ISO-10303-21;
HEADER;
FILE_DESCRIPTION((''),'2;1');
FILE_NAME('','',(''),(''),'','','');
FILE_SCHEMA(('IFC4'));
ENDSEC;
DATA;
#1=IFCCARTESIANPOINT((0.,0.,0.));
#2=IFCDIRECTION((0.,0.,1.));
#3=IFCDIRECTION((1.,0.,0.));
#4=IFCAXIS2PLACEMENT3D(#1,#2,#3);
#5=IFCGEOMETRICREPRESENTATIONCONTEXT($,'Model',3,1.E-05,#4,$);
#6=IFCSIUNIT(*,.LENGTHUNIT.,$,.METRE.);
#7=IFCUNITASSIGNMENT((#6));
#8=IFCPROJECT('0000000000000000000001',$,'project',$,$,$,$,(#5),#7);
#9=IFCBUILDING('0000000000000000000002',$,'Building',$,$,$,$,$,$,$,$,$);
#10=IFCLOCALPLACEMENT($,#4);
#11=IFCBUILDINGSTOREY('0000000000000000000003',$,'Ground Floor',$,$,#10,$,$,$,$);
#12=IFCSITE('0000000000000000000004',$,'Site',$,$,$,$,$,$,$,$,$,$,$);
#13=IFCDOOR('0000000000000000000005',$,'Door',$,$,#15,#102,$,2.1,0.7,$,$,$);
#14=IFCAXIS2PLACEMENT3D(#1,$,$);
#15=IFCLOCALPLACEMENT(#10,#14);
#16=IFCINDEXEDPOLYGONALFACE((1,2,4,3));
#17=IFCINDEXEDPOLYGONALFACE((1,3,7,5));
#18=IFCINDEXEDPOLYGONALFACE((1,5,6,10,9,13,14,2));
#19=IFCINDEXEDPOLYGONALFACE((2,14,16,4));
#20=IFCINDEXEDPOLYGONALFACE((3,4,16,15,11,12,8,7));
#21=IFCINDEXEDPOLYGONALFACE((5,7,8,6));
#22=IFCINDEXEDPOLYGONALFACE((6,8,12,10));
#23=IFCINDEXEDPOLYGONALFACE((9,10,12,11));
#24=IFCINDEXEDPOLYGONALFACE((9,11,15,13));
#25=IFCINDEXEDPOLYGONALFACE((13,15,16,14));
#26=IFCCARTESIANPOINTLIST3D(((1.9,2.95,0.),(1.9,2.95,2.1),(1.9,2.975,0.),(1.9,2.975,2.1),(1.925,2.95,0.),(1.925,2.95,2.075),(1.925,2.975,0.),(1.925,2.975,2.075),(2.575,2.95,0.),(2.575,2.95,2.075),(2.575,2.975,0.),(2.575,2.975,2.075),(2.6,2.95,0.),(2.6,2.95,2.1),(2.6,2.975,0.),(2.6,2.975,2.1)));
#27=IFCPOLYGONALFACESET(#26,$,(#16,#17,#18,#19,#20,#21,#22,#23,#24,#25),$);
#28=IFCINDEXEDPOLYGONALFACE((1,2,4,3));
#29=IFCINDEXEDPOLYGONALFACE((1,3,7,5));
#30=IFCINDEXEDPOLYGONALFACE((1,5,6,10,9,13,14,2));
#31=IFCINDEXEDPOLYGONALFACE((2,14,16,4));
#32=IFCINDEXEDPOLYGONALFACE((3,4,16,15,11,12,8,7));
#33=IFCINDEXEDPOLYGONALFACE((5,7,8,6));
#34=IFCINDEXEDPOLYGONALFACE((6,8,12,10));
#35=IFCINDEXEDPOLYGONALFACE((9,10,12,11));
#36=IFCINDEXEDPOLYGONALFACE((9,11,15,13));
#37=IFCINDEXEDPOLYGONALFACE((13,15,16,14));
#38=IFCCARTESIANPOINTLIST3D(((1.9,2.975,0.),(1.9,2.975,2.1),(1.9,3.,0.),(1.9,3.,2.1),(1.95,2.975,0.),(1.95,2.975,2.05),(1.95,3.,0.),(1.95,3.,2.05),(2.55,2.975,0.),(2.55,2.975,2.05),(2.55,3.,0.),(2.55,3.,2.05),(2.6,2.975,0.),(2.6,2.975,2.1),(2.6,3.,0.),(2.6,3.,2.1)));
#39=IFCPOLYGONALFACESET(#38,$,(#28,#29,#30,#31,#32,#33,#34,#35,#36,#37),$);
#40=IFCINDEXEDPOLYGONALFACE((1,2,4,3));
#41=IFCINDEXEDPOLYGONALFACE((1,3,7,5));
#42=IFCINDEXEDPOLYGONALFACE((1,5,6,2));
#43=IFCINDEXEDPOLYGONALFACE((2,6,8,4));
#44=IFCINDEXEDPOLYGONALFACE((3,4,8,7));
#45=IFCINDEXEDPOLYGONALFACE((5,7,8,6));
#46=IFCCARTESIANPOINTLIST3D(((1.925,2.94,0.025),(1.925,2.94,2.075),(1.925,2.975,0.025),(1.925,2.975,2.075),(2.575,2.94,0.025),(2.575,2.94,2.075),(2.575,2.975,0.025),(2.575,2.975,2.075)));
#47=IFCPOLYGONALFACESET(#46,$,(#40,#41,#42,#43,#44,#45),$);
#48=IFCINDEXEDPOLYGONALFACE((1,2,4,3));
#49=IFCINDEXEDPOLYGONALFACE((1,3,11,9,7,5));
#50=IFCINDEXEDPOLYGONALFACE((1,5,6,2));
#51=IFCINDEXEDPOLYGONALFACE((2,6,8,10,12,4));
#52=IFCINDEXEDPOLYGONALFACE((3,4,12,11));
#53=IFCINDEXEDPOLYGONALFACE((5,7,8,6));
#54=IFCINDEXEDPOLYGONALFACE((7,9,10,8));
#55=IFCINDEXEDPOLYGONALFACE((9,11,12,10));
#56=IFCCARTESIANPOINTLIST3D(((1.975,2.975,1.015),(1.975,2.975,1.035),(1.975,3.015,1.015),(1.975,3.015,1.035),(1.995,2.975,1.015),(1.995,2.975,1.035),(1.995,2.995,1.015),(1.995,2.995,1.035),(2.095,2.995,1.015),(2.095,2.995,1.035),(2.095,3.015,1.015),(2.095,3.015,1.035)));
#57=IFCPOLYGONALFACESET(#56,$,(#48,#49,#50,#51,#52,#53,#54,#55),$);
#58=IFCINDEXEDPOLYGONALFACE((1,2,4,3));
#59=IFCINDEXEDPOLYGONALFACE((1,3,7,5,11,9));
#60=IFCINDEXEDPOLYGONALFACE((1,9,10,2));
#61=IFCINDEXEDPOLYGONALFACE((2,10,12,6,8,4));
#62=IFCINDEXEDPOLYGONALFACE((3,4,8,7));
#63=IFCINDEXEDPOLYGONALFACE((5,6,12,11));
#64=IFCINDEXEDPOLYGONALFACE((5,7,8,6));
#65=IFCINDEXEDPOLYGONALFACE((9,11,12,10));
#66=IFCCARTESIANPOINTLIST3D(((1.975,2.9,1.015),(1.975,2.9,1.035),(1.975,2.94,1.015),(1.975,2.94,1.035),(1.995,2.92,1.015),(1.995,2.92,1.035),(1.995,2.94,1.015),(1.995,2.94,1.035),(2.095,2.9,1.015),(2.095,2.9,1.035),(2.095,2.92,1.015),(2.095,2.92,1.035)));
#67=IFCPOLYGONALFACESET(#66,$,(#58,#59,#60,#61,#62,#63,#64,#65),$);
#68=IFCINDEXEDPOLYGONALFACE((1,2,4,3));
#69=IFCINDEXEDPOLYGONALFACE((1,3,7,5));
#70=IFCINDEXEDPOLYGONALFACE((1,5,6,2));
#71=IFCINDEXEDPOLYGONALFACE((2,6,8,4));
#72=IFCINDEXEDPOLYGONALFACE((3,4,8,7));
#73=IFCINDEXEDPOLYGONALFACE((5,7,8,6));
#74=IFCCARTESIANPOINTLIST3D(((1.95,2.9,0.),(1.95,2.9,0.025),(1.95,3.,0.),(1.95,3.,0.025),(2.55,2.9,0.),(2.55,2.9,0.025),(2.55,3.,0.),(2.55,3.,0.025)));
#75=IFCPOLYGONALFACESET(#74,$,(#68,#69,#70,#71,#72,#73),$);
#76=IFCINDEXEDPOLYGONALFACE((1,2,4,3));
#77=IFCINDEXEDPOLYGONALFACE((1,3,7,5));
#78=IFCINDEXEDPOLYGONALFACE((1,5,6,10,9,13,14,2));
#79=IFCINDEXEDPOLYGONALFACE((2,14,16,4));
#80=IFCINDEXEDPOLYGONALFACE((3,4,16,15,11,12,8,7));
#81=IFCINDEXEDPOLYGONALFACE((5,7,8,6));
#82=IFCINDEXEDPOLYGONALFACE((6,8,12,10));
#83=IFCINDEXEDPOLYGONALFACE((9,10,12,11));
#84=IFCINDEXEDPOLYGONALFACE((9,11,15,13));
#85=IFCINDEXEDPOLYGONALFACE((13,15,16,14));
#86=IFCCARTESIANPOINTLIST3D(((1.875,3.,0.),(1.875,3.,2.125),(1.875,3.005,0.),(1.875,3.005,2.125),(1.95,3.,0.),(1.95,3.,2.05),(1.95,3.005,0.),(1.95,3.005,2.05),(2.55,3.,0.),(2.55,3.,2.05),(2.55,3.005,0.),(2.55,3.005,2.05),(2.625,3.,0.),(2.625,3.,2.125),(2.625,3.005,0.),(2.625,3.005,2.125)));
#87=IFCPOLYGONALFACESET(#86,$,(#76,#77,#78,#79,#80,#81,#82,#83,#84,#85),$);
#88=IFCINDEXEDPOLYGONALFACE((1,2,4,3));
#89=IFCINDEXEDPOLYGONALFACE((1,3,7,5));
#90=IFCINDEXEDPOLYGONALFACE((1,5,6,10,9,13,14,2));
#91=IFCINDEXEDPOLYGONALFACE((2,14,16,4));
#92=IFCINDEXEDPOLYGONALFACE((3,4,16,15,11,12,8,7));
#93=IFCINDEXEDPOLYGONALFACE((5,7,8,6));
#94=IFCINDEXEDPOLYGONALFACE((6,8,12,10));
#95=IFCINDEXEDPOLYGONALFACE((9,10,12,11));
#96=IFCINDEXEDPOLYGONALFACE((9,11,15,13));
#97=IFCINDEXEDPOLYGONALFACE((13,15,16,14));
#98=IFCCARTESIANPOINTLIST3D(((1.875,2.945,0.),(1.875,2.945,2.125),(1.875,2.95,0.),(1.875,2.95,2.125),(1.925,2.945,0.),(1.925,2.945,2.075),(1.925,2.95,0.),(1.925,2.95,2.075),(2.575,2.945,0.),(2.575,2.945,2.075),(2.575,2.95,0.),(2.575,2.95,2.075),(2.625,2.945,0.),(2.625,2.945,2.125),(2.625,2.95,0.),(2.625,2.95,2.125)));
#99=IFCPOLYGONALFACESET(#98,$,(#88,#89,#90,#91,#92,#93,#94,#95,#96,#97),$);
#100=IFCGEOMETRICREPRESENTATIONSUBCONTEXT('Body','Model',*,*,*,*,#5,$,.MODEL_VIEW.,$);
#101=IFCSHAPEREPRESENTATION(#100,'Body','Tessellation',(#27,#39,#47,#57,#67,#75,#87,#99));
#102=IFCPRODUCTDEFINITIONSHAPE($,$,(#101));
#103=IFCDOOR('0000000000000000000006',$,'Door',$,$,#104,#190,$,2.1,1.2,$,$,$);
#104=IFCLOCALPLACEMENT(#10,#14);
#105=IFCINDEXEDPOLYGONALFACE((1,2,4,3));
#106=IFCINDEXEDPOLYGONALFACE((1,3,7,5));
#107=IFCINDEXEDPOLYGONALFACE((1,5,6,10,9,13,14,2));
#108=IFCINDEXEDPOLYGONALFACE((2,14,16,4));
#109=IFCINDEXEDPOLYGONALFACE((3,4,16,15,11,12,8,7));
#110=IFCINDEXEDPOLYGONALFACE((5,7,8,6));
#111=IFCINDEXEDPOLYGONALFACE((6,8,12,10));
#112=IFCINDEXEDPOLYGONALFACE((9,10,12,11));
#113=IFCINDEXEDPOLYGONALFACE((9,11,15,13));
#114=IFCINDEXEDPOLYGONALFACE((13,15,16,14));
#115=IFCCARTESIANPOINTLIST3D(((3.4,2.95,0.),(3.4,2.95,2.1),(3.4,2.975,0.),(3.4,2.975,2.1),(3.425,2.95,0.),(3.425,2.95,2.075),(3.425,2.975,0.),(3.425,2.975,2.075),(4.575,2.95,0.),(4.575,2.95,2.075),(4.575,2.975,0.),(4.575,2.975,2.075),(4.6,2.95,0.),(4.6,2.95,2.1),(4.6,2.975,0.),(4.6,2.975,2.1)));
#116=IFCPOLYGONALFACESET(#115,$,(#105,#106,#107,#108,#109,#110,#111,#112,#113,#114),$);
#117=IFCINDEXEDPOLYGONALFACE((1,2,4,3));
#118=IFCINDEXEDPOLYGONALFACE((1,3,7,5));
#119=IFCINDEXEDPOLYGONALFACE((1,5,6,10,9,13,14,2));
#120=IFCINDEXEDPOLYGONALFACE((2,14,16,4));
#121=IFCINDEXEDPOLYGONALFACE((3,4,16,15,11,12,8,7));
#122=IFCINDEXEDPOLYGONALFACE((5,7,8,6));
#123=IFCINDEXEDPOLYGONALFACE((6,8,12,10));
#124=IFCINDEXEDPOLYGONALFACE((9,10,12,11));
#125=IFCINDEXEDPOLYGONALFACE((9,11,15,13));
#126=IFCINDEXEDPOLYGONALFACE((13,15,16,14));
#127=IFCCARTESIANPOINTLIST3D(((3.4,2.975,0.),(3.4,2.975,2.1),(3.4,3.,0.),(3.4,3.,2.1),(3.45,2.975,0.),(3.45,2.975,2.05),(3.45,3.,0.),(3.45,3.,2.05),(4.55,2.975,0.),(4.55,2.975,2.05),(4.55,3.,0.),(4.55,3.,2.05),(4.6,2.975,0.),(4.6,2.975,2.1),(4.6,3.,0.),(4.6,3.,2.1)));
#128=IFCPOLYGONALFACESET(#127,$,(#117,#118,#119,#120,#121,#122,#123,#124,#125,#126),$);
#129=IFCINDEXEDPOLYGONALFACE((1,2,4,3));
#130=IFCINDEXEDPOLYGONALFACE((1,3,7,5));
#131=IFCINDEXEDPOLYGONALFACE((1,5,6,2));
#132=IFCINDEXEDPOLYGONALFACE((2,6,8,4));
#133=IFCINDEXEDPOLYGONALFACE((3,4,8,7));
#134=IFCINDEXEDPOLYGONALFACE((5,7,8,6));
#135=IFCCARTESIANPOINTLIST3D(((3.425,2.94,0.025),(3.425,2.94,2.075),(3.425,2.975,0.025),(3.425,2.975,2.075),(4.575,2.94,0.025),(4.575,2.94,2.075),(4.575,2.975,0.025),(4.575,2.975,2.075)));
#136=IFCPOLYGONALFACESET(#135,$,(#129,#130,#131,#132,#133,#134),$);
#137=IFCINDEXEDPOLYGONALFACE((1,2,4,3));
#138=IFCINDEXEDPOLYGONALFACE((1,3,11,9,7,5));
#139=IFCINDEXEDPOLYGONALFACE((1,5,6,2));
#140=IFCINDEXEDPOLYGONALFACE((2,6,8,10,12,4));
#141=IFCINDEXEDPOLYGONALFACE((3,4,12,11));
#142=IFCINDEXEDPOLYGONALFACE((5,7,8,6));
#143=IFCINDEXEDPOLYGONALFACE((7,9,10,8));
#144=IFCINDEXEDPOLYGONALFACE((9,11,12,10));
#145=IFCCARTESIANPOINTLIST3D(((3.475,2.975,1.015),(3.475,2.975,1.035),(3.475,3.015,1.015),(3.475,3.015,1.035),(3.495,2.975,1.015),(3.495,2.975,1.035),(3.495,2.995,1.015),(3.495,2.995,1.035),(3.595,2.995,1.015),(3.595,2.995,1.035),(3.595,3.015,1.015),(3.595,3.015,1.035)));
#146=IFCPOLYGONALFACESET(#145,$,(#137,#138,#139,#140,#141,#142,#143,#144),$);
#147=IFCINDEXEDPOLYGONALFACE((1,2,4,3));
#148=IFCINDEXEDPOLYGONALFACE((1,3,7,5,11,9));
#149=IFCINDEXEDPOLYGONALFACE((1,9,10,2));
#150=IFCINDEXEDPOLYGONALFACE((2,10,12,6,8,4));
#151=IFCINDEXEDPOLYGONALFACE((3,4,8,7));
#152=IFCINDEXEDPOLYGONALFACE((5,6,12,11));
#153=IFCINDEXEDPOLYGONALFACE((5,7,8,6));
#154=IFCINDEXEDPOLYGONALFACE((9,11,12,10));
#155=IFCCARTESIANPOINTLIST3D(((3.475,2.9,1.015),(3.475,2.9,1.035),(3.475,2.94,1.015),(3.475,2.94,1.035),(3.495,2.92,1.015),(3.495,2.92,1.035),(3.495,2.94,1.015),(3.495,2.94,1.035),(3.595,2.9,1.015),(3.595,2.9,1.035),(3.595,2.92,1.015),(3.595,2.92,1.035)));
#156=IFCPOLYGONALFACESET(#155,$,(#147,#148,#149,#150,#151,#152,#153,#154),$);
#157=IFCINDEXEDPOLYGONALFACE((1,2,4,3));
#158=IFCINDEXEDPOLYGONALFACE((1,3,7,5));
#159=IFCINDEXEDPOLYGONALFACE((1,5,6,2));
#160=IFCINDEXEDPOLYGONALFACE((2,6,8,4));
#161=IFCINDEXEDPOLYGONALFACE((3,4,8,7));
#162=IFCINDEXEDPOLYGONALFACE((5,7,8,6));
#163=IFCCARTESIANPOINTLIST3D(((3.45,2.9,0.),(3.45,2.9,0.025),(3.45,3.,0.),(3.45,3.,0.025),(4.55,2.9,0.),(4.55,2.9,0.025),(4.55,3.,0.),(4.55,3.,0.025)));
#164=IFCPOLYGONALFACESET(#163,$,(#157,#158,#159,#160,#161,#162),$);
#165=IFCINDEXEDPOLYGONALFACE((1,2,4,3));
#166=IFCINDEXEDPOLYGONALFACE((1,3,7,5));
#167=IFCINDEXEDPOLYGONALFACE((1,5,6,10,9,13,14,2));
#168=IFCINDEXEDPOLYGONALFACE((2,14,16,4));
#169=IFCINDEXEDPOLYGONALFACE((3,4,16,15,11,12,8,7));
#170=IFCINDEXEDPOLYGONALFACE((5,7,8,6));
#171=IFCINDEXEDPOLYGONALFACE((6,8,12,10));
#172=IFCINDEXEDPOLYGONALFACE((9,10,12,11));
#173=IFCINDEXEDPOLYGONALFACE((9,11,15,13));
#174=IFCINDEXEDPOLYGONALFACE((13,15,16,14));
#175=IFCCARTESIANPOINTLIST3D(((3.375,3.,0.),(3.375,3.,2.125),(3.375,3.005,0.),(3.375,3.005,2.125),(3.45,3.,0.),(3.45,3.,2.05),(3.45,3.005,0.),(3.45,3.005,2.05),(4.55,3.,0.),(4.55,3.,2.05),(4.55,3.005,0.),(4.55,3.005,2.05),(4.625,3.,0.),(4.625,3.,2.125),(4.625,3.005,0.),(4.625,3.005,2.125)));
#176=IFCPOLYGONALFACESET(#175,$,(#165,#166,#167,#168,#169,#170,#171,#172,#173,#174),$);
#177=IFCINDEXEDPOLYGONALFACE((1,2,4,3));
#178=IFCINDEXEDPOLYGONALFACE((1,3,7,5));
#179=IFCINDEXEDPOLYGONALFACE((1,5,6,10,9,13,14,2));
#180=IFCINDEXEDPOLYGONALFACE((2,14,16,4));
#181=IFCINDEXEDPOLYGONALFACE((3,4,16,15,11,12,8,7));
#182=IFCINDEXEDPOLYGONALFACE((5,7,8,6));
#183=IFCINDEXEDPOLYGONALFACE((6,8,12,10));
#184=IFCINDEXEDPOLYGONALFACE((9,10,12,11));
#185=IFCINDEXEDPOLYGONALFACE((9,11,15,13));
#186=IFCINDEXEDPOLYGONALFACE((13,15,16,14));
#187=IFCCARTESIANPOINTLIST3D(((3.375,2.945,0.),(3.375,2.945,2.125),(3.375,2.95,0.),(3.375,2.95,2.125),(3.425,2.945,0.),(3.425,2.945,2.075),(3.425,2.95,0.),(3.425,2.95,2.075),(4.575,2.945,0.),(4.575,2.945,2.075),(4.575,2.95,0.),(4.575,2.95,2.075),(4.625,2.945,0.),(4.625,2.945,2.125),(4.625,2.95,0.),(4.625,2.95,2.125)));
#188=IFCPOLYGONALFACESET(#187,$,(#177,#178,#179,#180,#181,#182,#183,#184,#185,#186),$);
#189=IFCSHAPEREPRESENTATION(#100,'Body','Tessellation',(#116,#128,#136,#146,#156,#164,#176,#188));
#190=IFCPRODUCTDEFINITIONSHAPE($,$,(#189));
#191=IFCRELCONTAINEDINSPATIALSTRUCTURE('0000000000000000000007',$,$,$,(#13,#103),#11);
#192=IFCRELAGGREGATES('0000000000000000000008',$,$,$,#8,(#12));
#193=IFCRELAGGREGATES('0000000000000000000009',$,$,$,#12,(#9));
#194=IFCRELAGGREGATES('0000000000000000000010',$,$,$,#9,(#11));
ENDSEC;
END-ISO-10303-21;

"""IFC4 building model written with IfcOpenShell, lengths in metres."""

from ifc_helpers import new_model, si_unit, frame, origin_with_axes, place, context, subcontext, project, spatial, line, indexed_curve, outline, extrude, element, save


model = new_model("IFC4")

# Units and contexts
model_context = context("Model", 3, precision=1e-05, world=origin_with_axes())
body_context = subcontext(model_context, "Body", "Model", "MODEL_VIEW")
ifc_project = project(units=[si_unit("LENGTHUNIT", "METRE")], contexts=[model_context])

# Site, building, storey
site = spatial("IfcSite", under=ifc_project, Name="Site")
building = spatial("IfcBuilding", under=site, Name="Building")
storey_placement = place(None, origin_with_axes())
storey = spatial("IfcBuildingStorey", under=building, at=storey_placement, Name="Ground Floor")

# Doors
door_1_placement = place(storey_placement, frame((2.6, 3.0, 0.0), z_axis=(0.0, 0.0, 1.0), x_axis=(-1.0, 0.0, 0.0)))
element("IfcDoor", 1, at=door_1_placement, inside=storey, Name="Door", OverallHeight=2.1, OverallWidth=0.7, context=body_context, shape_type="SweptSolid", body=[
    extrude(outline(indexed_curve([(0.0, 0.0), (0.0, 2.1), (0.7, 2.1), (0.7, 0.0), (0.675, 0.0), (0.675, 2.075), (0.025, 2.075), (0.025, 0.0)], segments=[line(1, 2, 3, 4, 5, 6, 7, 8, 1)])), frame((0.0, 0.025, 0.0), z_axis=(0.0, -1.0, 0.0), x_axis=(1.0, 0.0, 0.0)), (0.0, 0.0, -1.0), 0.025),
    extrude(outline(indexed_curve([(0.0, 0.0), (0.0, 2.1), (0.7, 2.1), (0.7, 0.0), (0.65, 0.0), (0.65, 2.05), (0.05, 2.05), (0.05, 0.0)], segments=[line(1, 2, 3, 4, 5, 6, 7, 8, 1)])), frame((0.0, 0.0, 0.0), z_axis=(0.0, -1.0, 0.0), x_axis=(1.0, 0.0, 0.0)), (0.0, 0.0, -1.0), 0.025),
    extrude(outline(indexed_curve([(0.0, 0.0), (0.65, 0.0), (0.65, 0.035), (0.0, 0.035)], segments=[line(1, 2, 3, 4, 1)])), frame((0.025, 0.025, 0.025), z_axis=(0.0, 0.0, 1.0), x_axis=(1.0, 0.0, 0.0)), (0.0, 0.0, 1.0), 2.05),
    extrude(outline(indexed_curve([(0.0, 0.0), (0.0, -0.04), (-0.12, -0.04), (-0.12, -0.02), (-0.02, -0.02), (-0.02, 0.0)], segments=[line(1, 2, 3, 4, 5, 6, 1)])), frame((0.625, 0.025, 1.015), z_axis=(0.0, 0.0, 1.0), x_axis=(1.0, 0.0, 0.0)), (0.0, 0.0, 1.0), 0.02),
    extrude(outline(indexed_curve([(0.0, 0.0), (0.0, 0.04), (-0.12, 0.04), (-0.12, 0.02), (-0.02, 0.02), (-0.02, 0.0)], segments=[line(1, 2, 3, 4, 5, 6, 1)])), frame((0.625, 0.06, 1.015), z_axis=(0.0, 0.0, 1.0), x_axis=(1.0, 0.0, 0.0)), (0.0, 0.0, 1.0), 0.02),
    extrude(outline(indexed_curve([(0.0, 0.0), (0.6, 0.0), (0.6, 0.1), (0.0, 0.1)], segments=[line(1, 2, 3, 4, 1)])), frame((0.05, 0.0, 0.0), z_axis=(0.0, 0.0, 1.0), x_axis=(1.0, 0.0, 0.0)), (0.0, 0.0, 1.0), 0.025),
    extrude(outline(indexed_curve([(0.0, 0.0), (0.0, 2.125), (0.75, 2.125), (0.75, 0.0), (0.675, 0.0), (0.675, 2.05), (0.075, 2.05), (0.075, 0.0)], segments=[line(1, 2, 3, 4, 5, 6, 7, 8, 1)])), frame((-0.025, -0.005, 0.0), z_axis=(0.0, -1.0, 0.0), x_axis=(1.0, 0.0, 0.0)), (0.0, 0.0, -1.0), 0.005),
    extrude(outline(indexed_curve([(0.0, 0.0), (0.0, 2.125), (0.75, 2.125), (0.75, 0.0), (0.7, 0.0), (0.7, 2.075), (0.05, 2.075), (0.05, 0.0)], segments=[line(1, 2, 3, 4, 5, 6, 7, 8, 1)])), frame((-0.025, 0.05, 0.0), z_axis=(0.0, -1.0, 0.0), x_axis=(1.0, 0.0, 0.0)), (0.0, 0.0, -1.0), 0.005),
])
door_2_placement = place(storey_placement, frame((4.6, 3.0, 0.0), z_axis=(0.0, 0.0, 1.0), x_axis=(-1.0, 0.0, 0.0)))
element("IfcDoor", 2, at=door_2_placement, inside=storey, Name="Door", OverallHeight=2.1, OverallWidth=1.2, context=body_context, shape_type="SweptSolid", body=[
    extrude(outline(indexed_curve([(0.0, 0.0), (0.0, 2.1), (1.2, 2.1), (1.2, 0.0), (1.175, 0.0), (1.175, 2.075), (0.025, 2.075), (0.025, 0.0)], segments=[line(1, 2, 3, 4, 5, 6, 7, 8, 1)])), frame((0.0, 0.025, 0.0), z_axis=(0.0, -1.0, 0.0), x_axis=(1.0, 0.0, 0.0)), (0.0, 0.0, -1.0), 0.025),
    extrude(outline(indexed_curve([(0.0, 0.0), (0.0, 2.1), (1.2, 2.1), (1.2, 0.0), (1.15, 0.0), (1.15, 2.05), (0.05, 2.05), (0.05, 0.0)], segments=[line(1, 2, 3, 4, 5, 6, 7, 8, 1)])), frame((0.0, 0.0, 0.0), z_axis=(0.0, -1.0, 0.0), x_axis=(1.0, 0.0, 0.0)), (0.0, 0.0, -1.0), 0.025),
    extrude(outline(indexed_curve([(0.0, 0.0), (1.15, 0.0), (1.15, 0.035), (0.0, 0.035)], segments=[line(1, 2, 3, 4, 1)])), frame((0.025, 0.025, 0.025), z_axis=(0.0, 0.0, 1.0), x_axis=(1.0, 0.0, 0.0)), (0.0, 0.0, 1.0), 2.05),
    extrude(outline(indexed_curve([(0.0, 0.0), (0.0, -0.04), (-0.12, -0.04), (-0.12, -0.02), (-0.02, -0.02), (-0.02, 0.0)], segments=[line(1, 2, 3, 4, 5, 6, 1)])), frame((1.125, 0.025, 1.015), z_axis=(0.0, 0.0, 1.0), x_axis=(1.0, 0.0, 0.0)), (0.0, 0.0, 1.0), 0.02),
    extrude(outline(indexed_curve([(0.0, 0.0), (0.0, 0.04), (-0.12, 0.04), (-0.12, 0.02), (-0.02, 0.02), (-0.02, 0.0)], segments=[line(1, 2, 3, 4, 5, 6, 1)])), frame((1.125, 0.06, 1.015), z_axis=(0.0, 0.0, 1.0), x_axis=(1.0, 0.0, 0.0)), (0.0, 0.0, 1.0), 0.02),
    extrude(outline(indexed_curve([(0.0, 0.0), (1.1, 0.0), (1.1, 0.1), (0.0, 0.1)], segments=[line(1, 2, 3, 4, 1)])), frame((0.05, 0.0, 0.0), z_axis=(0.0, 0.0, 1.0), x_axis=(1.0, 0.0, 0.0)), (0.0, 0.0, 1.0), 0.025),
    extrude(outline(indexed_curve([(0.0, 0.0), (0.0, 2.125), (1.25, 2.125), (1.25, 0.0), (1.175, 0.0), (1.175, 2.05), (0.075, 2.05), (0.075, 0.0)], segments=[line(1, 2, 3, 4, 5, 6, 7, 8, 1)])), frame((-0.025, -0.005, 0.0), z_axis=(0.0, -1.0, 0.0), x_axis=(1.0, 0.0, 0.0)), (0.0, 0.0, -1.0), 0.005),
    extrude(outline(indexed_curve([(0.0, 0.0), (0.0, 2.125), (1.25, 2.125), (1.25, 0.0), (1.2, 0.0), (1.2, 2.075), (0.05, 2.075), (0.05, 0.0)], segments=[line(1, 2, 3, 4, 5, 6, 7, 8, 1)])), frame((-0.025, 0.05, 0.0), z_axis=(0.0, -1.0, 0.0), x_axis=(1.0, 0.0, 0.0)), (0.0, 0.0, -1.0), 0.005),
])

save(model, "model.ifc")
